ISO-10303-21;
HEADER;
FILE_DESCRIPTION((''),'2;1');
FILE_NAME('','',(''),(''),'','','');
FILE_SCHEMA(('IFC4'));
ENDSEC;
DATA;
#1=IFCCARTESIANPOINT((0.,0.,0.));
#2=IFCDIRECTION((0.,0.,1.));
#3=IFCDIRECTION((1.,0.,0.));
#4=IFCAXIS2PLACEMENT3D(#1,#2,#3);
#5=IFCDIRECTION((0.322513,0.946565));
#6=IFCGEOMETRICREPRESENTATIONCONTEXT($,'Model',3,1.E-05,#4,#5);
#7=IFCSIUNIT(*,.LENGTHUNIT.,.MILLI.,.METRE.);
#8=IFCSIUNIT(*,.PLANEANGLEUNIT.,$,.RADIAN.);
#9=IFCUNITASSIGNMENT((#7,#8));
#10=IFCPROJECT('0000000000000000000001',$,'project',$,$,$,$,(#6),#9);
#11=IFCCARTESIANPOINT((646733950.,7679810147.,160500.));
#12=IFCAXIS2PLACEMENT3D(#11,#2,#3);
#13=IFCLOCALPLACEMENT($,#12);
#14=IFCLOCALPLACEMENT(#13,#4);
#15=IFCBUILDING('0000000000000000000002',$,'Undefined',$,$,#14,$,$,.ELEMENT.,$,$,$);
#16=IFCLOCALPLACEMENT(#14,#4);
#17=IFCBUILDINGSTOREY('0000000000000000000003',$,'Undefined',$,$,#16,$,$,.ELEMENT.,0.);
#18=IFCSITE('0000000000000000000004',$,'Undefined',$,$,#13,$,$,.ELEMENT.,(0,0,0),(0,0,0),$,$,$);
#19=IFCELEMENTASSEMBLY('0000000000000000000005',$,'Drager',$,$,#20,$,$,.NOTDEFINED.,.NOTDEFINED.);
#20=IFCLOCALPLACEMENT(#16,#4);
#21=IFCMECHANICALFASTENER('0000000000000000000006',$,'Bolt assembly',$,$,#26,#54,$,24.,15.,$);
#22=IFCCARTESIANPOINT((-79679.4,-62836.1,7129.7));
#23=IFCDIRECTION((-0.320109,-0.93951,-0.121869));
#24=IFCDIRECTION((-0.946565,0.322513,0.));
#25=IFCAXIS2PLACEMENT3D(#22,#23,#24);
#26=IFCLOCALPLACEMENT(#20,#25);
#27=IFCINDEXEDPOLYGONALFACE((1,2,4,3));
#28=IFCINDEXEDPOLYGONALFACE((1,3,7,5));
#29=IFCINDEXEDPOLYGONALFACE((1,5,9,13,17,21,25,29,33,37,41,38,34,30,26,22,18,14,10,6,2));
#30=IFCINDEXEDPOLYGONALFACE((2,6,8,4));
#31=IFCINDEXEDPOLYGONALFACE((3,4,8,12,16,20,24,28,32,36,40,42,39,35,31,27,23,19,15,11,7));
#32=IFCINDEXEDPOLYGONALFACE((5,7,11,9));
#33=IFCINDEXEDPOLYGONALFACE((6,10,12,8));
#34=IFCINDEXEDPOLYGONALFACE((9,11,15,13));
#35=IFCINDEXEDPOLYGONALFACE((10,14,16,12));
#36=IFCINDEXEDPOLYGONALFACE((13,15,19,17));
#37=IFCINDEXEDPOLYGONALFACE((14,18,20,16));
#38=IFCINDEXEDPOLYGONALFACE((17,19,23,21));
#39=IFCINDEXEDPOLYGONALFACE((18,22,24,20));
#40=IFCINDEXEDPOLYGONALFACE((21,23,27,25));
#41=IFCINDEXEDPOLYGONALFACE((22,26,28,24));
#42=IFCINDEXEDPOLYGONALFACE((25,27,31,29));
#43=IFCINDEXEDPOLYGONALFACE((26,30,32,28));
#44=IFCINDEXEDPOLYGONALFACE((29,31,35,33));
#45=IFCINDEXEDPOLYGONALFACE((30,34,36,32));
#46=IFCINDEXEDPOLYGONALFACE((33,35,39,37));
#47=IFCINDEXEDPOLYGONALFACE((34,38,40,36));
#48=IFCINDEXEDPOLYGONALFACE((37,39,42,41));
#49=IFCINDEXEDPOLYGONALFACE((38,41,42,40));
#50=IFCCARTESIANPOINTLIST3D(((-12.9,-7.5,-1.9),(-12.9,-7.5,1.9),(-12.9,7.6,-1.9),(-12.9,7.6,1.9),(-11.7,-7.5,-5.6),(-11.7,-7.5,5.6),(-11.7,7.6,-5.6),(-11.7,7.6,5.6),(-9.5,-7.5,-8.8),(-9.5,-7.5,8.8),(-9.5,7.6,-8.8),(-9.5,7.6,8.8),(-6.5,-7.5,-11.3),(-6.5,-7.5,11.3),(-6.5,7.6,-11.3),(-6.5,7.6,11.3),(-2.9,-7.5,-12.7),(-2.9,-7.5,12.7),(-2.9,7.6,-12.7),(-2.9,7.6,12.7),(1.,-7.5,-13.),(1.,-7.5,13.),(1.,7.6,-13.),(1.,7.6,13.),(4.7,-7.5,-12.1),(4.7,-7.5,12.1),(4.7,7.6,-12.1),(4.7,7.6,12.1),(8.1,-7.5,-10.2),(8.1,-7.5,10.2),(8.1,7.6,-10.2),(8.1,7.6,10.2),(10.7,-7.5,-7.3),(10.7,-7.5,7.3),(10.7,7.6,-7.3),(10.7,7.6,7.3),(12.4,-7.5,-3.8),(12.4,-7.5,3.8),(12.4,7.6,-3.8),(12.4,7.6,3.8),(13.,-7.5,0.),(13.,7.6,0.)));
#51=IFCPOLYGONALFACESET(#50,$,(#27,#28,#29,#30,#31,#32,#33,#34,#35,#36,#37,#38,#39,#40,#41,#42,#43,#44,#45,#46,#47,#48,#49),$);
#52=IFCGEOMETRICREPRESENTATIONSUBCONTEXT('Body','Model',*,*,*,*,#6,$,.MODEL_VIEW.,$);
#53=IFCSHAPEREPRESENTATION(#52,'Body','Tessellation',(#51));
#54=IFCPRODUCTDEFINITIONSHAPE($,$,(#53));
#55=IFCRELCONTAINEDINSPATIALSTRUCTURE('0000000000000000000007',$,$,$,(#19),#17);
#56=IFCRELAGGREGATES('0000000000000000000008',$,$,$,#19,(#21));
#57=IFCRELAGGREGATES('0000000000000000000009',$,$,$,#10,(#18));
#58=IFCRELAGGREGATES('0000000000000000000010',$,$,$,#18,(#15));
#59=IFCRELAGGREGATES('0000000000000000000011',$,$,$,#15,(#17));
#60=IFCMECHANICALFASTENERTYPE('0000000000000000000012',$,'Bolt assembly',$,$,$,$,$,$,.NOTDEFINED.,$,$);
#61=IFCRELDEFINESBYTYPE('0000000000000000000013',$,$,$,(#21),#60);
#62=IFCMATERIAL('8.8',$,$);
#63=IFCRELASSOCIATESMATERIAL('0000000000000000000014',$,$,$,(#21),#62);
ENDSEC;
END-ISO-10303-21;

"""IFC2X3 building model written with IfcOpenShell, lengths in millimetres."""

from ifc_helpers import new_model, si_unit, direction, frame, origin_with_axes, origin_2d_with_axis, place, context, subcontext, project, spatial, circle, extrude, source, transform, mapped, material, type_object, element, aggregate, save


model = new_model("IFC2X3")

# Units and contexts
model_context = context("Model", 3, precision=1e-05, world=origin_with_axes(), true_north=direction((0.322513, 0.946565)))
body_context = subcontext(model_context, "Body", "Model", "MODEL_VIEW")
ifc_project = project(units=[si_unit("LENGTHUNIT", "METRE", prefix="MILLI"), si_unit("PLANEANGLEUNIT", "RADIAN")], contexts=[model_context])

# Site, building, storey
site_placement = place(None, frame((646733950.0, 7679810147.0, 160500.0), z_axis=(0.0, 0.0, 1.0), x_axis=(1.0, 0.0, 0.0)))
site = spatial("IfcSite", under=ifc_project, at=site_placement, Name="Undefined", CompositionType="ELEMENT", RefLatitude=(0, 0, 0), RefLongitude=(0, 0, 0))
building_placement = place(site_placement, origin_with_axes())
building = spatial("IfcBuilding", under=site, at=building_placement, Name="Undefined", CompositionType="ELEMENT")
storey_placement = place(building_placement, origin_with_axes())
storey = spatial("IfcBuildingStorey", under=building, at=storey_placement, Name="Undefined", CompositionType="ELEMENT", Elevation=0.0)

# Element assembly
assembly_1_placement = place(storey_placement, origin_with_axes())
assembly_1 = element("IfcElementAssembly", 1, at=assembly_1_placement, inside=storey, Name="Drager", AssemblyPlace="NOTDEFINED", PredefinedType="NOTDEFINED")

# Shared definitions
ifc_material_1 = material(Name="8.8")
mechanical_fastener_type = type_object("IfcMechanicalFastenerType", Name="Bolt assembly")

# Mechanical fastener
shared_shape_1 = source(origin_with_axes(), body_context, "Body", "SweptSolid", [
    extrude(circle(Radius=13.0, at=origin_2d_with_axis()), frame((0.0, -7.5, 0.0), z_axis=(0.0, 1.0, 0.0), x_axis=(1.0, 0.0, 0.0)), (0.0, 0.0, 1.0), 15.1),
])
mechanical_fastener_1_placement = place(assembly_1_placement, frame((-79679.4, -62836.1, 7129.7), z_axis=(-0.320109, -0.93951, -0.121869), x_axis=(-0.946565, 0.322513, 0.0)))
mechanical_fastener_1 = element("IfcMechanicalFastener", 2, at=mechanical_fastener_1_placement, type_object=mechanical_fastener_type, material=ifc_material_1, Name="Bolt assembly", NominalDiameter=24.0, NominalLength=15.0, context=body_context, shape_type="MappedRepresentation", body=[
    mapped(shared_shape_1, transform((0.0, 0.0, 0.0))),
])
aggregate(assembly_1, [mechanical_fastener_1])

save(model, "model.ifc")
